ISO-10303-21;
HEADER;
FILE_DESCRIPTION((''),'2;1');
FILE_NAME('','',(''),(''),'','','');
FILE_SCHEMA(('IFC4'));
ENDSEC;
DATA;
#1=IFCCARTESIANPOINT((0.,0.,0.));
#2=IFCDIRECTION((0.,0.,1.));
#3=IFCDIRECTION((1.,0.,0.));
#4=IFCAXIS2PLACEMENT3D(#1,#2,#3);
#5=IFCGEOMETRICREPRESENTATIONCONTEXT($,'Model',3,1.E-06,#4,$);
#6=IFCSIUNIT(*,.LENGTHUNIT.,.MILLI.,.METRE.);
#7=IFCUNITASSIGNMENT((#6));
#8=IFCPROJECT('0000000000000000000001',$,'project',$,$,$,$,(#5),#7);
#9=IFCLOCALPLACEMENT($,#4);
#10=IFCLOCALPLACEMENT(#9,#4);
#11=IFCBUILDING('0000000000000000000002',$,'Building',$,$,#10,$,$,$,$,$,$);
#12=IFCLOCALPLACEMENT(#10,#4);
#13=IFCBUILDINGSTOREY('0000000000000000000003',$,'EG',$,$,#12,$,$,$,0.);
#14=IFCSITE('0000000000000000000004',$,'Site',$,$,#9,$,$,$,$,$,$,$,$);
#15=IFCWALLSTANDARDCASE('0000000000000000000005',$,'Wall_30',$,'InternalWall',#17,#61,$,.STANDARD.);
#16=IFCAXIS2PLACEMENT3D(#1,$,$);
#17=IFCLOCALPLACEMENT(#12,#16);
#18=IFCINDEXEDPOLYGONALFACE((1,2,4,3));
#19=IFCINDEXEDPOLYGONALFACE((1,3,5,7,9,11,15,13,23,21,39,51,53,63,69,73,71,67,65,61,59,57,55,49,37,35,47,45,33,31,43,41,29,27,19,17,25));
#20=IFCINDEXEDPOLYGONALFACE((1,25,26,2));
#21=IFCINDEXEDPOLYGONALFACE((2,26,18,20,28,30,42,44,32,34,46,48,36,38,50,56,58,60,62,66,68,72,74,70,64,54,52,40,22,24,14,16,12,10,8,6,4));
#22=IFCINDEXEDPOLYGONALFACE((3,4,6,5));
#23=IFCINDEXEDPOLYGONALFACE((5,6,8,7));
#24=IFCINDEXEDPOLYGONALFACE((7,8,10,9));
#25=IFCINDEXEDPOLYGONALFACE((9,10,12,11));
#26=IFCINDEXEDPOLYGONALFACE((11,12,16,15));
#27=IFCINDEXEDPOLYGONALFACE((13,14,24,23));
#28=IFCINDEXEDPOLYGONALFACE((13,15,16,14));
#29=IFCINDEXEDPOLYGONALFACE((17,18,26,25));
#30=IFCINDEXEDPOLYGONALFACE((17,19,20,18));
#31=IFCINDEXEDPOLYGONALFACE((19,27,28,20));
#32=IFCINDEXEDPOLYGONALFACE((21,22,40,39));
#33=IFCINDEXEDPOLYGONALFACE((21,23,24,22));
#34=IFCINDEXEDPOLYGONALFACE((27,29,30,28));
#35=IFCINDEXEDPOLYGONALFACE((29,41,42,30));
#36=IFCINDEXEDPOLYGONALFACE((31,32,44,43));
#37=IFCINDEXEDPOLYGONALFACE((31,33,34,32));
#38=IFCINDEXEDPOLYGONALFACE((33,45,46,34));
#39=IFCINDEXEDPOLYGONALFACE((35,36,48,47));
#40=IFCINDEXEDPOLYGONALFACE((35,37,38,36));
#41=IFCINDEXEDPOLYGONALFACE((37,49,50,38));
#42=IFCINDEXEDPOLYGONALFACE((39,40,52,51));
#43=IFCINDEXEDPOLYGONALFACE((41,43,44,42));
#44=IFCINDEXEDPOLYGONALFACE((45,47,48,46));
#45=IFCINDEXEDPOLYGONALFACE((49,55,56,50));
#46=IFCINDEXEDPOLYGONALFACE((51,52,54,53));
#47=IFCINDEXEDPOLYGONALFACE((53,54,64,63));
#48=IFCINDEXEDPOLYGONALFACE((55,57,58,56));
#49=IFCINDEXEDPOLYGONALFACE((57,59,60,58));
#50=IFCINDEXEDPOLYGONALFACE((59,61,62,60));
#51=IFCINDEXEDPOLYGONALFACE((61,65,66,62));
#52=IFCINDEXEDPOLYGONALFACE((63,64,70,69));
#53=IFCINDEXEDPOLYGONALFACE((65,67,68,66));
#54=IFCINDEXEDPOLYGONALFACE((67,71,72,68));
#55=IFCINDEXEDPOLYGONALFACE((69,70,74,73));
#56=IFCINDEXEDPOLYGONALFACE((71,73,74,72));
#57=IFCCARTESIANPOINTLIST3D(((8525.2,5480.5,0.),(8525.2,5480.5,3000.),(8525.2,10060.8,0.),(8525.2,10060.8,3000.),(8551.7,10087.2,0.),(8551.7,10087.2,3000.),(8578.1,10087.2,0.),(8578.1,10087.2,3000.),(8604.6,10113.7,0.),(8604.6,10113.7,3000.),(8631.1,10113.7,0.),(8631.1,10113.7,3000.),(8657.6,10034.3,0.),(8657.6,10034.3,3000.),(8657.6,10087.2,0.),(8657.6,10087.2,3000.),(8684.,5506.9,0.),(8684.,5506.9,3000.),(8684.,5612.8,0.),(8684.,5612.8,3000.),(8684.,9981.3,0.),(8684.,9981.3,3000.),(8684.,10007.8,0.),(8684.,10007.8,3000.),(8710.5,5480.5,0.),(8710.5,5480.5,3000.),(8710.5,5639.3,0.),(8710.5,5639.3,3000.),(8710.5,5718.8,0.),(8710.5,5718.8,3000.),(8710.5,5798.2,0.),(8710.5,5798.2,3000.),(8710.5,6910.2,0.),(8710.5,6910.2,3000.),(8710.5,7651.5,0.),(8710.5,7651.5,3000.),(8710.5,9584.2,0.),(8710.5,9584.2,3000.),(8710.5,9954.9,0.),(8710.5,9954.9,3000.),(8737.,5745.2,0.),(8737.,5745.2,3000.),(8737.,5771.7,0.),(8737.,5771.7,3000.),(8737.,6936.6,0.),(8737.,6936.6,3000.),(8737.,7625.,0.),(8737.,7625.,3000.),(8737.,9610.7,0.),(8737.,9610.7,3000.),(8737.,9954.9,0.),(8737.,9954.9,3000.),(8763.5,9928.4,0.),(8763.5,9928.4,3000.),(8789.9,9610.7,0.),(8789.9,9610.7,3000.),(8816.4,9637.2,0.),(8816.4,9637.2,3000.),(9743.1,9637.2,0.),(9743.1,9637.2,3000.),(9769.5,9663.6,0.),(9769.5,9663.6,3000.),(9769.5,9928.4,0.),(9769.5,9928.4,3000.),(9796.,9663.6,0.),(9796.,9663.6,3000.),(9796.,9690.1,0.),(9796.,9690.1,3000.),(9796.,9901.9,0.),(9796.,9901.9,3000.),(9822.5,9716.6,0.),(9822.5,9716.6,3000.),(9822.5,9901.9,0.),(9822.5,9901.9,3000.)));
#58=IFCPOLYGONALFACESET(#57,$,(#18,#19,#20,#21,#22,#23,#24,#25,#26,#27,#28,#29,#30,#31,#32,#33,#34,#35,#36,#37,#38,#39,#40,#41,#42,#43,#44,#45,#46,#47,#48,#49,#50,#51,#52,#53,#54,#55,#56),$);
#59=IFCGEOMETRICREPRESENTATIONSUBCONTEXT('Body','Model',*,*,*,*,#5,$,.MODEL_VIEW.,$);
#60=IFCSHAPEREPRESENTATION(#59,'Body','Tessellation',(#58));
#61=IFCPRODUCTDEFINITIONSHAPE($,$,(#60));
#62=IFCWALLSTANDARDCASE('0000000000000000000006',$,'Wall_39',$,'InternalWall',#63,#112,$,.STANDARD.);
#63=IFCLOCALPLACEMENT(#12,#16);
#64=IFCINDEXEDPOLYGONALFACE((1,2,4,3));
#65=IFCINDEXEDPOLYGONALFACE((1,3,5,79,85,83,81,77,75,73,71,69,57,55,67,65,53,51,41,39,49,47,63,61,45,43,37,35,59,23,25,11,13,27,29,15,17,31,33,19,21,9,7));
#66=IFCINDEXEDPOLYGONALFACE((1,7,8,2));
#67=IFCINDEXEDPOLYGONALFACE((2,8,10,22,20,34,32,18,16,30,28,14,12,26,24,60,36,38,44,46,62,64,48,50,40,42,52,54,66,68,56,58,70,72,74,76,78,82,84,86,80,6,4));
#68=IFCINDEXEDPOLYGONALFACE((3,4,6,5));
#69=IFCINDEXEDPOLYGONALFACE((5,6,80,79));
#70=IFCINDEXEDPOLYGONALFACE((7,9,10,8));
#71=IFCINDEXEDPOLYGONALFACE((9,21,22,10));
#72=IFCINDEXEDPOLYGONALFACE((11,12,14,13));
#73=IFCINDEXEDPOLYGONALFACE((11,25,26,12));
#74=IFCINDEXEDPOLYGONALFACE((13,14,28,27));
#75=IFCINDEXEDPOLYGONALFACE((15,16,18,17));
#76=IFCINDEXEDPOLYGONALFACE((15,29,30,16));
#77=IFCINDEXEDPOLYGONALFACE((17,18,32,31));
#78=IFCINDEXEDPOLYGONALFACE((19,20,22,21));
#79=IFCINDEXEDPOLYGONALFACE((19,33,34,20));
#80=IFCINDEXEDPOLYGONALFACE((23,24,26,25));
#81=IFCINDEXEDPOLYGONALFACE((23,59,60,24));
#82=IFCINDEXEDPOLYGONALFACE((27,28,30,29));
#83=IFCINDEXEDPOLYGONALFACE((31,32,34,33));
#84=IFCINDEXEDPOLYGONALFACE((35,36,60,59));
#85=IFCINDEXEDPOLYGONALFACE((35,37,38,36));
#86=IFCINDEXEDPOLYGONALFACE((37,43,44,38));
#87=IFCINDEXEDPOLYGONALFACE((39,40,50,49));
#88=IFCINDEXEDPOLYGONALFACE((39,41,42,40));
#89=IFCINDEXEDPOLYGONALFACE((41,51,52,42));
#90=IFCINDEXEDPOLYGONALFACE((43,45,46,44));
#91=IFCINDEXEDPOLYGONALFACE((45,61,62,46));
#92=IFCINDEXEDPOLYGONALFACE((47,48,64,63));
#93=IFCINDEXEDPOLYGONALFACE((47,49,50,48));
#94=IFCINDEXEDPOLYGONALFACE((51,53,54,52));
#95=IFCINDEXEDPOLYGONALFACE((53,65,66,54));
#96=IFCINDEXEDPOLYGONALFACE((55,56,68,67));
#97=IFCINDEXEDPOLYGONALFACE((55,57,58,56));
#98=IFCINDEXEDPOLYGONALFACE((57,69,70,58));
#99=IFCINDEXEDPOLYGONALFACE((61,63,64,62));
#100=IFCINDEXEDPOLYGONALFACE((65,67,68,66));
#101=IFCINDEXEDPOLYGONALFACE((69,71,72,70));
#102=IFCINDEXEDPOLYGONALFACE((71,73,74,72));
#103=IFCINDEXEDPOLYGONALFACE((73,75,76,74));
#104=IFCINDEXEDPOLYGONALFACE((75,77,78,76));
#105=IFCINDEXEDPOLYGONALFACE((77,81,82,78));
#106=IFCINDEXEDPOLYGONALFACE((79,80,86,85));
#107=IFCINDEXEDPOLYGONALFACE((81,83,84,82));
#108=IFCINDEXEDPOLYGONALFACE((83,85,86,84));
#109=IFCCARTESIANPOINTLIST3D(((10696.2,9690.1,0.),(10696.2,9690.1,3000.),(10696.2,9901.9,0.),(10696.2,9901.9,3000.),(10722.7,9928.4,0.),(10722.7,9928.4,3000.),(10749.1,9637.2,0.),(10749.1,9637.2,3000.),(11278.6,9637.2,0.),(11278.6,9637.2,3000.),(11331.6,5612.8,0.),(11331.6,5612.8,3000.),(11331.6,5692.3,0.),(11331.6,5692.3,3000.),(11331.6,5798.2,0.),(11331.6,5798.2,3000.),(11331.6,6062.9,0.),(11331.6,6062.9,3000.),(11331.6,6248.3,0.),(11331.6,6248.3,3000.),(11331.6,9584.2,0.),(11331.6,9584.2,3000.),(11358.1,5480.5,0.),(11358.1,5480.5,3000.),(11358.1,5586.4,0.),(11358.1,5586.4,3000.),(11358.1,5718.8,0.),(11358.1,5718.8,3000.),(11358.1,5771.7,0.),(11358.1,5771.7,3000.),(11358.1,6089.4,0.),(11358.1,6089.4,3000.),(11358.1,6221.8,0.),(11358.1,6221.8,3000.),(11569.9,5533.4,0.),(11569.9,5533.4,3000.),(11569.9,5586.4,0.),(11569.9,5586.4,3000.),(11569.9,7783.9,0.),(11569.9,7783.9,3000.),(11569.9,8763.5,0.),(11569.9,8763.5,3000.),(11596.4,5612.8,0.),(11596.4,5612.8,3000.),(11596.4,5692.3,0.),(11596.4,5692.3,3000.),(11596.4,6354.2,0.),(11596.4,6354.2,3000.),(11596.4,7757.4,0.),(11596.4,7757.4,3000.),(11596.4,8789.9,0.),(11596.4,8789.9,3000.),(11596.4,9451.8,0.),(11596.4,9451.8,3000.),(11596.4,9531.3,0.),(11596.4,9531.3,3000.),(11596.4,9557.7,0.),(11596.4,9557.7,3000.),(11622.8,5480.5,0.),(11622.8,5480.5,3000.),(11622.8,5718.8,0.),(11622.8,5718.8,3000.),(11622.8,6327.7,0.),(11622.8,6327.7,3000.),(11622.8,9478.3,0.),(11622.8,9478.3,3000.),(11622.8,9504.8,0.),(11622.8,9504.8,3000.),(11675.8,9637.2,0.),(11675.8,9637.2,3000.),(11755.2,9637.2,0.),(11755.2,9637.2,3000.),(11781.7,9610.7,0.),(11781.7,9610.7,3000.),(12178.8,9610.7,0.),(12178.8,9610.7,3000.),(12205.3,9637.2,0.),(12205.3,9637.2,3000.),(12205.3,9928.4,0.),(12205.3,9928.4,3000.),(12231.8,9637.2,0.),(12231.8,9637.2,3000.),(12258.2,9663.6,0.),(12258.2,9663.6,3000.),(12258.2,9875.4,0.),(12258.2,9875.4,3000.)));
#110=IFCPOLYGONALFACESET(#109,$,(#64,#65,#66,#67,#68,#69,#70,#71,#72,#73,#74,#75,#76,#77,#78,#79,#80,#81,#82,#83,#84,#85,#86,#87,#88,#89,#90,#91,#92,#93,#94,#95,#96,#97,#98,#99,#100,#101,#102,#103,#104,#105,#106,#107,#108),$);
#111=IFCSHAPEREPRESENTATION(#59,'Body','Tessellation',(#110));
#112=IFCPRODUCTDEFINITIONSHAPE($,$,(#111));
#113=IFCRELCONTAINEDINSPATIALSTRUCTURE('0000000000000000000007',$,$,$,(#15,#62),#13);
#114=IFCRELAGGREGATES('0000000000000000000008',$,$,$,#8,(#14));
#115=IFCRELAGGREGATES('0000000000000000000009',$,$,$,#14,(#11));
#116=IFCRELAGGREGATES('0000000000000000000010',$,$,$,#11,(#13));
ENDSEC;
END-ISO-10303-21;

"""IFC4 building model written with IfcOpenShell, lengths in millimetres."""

from ifc_helpers import new_model, si_unit, frame, origin_with_axes, place, context, subcontext, project, spatial, polyline, outline, extrude, element, save


model = new_model("IFC4")

# Units and contexts
model_context = context("Model", 3, precision=1e-06, world=origin_with_axes())
body_context = subcontext(model_context, "Body", "Model", "MODEL_VIEW")
ifc_project = project(units=[si_unit("LENGTHUNIT", "METRE", prefix="MILLI")], contexts=[model_context])

# Site, building, storey
site_placement = place(None, origin_with_axes())
site = spatial("IfcSite", under=ifc_project, at=site_placement, Name="Site")
building_placement = place(site_placement, origin_with_axes())
building = spatial("IfcBuilding", under=site, at=building_placement, Name="Building")
storey_placement = place(building_placement, origin_with_axes())
storey = spatial("IfcBuildingStorey", under=building, at=storey_placement, Name="EG", Elevation=0.0)

# Walls
for number, where, z_axis, x_axis, name in (
    (1, (0.0, 0.0, 0.0), (0.0, 0.0, 1.0), (1.0, 0.0, 0.0), "Wall_30"),
):
    element("IfcWallStandardCase", number, at=place(storey_placement, frame(where, z_axis=z_axis, x_axis=x_axis)), inside=storey, Name=name, ObjectType="InternalWall", PredefinedType="STANDARD", context=body_context, shape_type="SweptSolid", body=[
        extrude(outline(polyline([(8525.2, 5480.5, 0.0), (8525.2, 10060.8, 0.0), (8551.7, 10087.2, 0.0), (8578.1, 10087.2, 0.0), (8604.6, 10113.7, 0.0), (8631.1, 10113.7, 0.0), (8657.6, 10087.2, 0.0), (8657.6, 10034.3, 0.0), (8684.0, 10007.8, 0.0), (8684.0, 9981.3, 0.0), (8710.5, 9954.9, 0.0), (8737.0, 9954.9, 0.0), (8763.5, 9928.4, 0.0), (9769.5, 9928.4, 0.0), (9796.0, 9901.9, 0.0), (9822.5, 9901.9, 0.0), (9822.5, 9716.6, 0.0), (9796.0, 9690.1, 0.0), (9796.0, 9663.6, 0.0), (9769.5, 9663.6, 0.0), (9743.1, 9637.2, 0.0), (8816.4, 9637.2, 0.0), (8789.9, 9610.7, 0.0), (8737.0, 9610.7, 0.0), (8710.5, 9584.2, 0.0), (8710.5, 7651.5, 0.0), (8737.0, 7625.0, 0.0), (8737.0, 6936.6, 0.0), (8710.5, 6910.2, 0.0), (8710.5, 5798.2, 0.0), (8737.0, 5771.7, 0.0), (8737.0, 5745.2, 0.0), (8710.5, 5718.8, 0.0), (8710.5, 5639.3, 0.0), (8684.0, 5612.8, 0.0), (8684.0, 5506.9, 0.0), (8710.5, 5480.5, 0.0), (8525.2, 5480.5, 0.0)])), origin_with_axes(), (0.0, 0.0, 1.0), 3000.0),
    ])
wall_1_placement = place(storey_placement, origin_with_axes())
element("IfcWallStandardCase", 2, at=wall_1_placement, inside=storey, Name="Wall_39", ObjectType="InternalWall", PredefinedType="STANDARD", context=body_context, shape_type="SweptSolid", body=[
    extrude(outline(polyline([(11358.1, 5480.5, 0.0), (11358.1, 5586.4, 0.0), (11331.6, 5612.8, 0.0), (11331.6, 5692.3, 0.0), (11358.1, 5718.8, 0.0), (11358.1, 5771.7, 0.0), (11331.6, 5798.2, 0.0), (11331.6, 6062.9, 0.0), (11358.1, 6089.4, 0.0), (11358.1, 6221.8, 0.0), (11331.6, 6248.3, 0.0), (11331.6, 9584.2, 0.0), (11278.6, 9637.2, 0.0), (10749.1, 9637.2, 0.0), (10696.2, 9690.1, 0.0), (10696.2, 9901.9, 0.0), (10722.7, 9928.4, 0.0), (12205.3, 9928.4, 0.0), (12258.2, 9875.4, 0.0), (12258.2, 9663.6, 0.0), (12231.8, 9637.2, 0.0), (12205.3, 9637.2, 0.0), (12178.8, 9610.7, 0.0), (11781.7, 9610.7, 0.0), (11755.2, 9637.2, 0.0), (11675.8, 9637.2, 0.0), (11596.4, 9557.7, 0.0), (11596.4, 9531.3, 0.0), (11622.8, 9504.8, 0.0), (11622.8, 9478.3, 0.0), (11596.4, 9451.8, 0.0), (11596.4, 8789.9, 0.0), (11569.9, 8763.5, 0.0), (11569.9, 7783.9, 0.0), (11596.4, 7757.4, 0.0), (11596.4, 6354.2, 0.0), (11622.8, 6327.7, 0.0), (11622.8, 5718.8, 0.0), (11596.4, 5692.3, 0.0), (11596.4, 5612.8, 0.0), (11569.9, 5586.4, 0.0), (11569.9, 5533.4, 0.0), (11622.8, 5480.5, 0.0), (11755.2, 5480.5, 0.0), (11358.1, 5480.5, 0.0)])), origin_with_axes(), (0.0, 0.0, 1.0), 3000.0),
])

save(model, "model.ifc")
